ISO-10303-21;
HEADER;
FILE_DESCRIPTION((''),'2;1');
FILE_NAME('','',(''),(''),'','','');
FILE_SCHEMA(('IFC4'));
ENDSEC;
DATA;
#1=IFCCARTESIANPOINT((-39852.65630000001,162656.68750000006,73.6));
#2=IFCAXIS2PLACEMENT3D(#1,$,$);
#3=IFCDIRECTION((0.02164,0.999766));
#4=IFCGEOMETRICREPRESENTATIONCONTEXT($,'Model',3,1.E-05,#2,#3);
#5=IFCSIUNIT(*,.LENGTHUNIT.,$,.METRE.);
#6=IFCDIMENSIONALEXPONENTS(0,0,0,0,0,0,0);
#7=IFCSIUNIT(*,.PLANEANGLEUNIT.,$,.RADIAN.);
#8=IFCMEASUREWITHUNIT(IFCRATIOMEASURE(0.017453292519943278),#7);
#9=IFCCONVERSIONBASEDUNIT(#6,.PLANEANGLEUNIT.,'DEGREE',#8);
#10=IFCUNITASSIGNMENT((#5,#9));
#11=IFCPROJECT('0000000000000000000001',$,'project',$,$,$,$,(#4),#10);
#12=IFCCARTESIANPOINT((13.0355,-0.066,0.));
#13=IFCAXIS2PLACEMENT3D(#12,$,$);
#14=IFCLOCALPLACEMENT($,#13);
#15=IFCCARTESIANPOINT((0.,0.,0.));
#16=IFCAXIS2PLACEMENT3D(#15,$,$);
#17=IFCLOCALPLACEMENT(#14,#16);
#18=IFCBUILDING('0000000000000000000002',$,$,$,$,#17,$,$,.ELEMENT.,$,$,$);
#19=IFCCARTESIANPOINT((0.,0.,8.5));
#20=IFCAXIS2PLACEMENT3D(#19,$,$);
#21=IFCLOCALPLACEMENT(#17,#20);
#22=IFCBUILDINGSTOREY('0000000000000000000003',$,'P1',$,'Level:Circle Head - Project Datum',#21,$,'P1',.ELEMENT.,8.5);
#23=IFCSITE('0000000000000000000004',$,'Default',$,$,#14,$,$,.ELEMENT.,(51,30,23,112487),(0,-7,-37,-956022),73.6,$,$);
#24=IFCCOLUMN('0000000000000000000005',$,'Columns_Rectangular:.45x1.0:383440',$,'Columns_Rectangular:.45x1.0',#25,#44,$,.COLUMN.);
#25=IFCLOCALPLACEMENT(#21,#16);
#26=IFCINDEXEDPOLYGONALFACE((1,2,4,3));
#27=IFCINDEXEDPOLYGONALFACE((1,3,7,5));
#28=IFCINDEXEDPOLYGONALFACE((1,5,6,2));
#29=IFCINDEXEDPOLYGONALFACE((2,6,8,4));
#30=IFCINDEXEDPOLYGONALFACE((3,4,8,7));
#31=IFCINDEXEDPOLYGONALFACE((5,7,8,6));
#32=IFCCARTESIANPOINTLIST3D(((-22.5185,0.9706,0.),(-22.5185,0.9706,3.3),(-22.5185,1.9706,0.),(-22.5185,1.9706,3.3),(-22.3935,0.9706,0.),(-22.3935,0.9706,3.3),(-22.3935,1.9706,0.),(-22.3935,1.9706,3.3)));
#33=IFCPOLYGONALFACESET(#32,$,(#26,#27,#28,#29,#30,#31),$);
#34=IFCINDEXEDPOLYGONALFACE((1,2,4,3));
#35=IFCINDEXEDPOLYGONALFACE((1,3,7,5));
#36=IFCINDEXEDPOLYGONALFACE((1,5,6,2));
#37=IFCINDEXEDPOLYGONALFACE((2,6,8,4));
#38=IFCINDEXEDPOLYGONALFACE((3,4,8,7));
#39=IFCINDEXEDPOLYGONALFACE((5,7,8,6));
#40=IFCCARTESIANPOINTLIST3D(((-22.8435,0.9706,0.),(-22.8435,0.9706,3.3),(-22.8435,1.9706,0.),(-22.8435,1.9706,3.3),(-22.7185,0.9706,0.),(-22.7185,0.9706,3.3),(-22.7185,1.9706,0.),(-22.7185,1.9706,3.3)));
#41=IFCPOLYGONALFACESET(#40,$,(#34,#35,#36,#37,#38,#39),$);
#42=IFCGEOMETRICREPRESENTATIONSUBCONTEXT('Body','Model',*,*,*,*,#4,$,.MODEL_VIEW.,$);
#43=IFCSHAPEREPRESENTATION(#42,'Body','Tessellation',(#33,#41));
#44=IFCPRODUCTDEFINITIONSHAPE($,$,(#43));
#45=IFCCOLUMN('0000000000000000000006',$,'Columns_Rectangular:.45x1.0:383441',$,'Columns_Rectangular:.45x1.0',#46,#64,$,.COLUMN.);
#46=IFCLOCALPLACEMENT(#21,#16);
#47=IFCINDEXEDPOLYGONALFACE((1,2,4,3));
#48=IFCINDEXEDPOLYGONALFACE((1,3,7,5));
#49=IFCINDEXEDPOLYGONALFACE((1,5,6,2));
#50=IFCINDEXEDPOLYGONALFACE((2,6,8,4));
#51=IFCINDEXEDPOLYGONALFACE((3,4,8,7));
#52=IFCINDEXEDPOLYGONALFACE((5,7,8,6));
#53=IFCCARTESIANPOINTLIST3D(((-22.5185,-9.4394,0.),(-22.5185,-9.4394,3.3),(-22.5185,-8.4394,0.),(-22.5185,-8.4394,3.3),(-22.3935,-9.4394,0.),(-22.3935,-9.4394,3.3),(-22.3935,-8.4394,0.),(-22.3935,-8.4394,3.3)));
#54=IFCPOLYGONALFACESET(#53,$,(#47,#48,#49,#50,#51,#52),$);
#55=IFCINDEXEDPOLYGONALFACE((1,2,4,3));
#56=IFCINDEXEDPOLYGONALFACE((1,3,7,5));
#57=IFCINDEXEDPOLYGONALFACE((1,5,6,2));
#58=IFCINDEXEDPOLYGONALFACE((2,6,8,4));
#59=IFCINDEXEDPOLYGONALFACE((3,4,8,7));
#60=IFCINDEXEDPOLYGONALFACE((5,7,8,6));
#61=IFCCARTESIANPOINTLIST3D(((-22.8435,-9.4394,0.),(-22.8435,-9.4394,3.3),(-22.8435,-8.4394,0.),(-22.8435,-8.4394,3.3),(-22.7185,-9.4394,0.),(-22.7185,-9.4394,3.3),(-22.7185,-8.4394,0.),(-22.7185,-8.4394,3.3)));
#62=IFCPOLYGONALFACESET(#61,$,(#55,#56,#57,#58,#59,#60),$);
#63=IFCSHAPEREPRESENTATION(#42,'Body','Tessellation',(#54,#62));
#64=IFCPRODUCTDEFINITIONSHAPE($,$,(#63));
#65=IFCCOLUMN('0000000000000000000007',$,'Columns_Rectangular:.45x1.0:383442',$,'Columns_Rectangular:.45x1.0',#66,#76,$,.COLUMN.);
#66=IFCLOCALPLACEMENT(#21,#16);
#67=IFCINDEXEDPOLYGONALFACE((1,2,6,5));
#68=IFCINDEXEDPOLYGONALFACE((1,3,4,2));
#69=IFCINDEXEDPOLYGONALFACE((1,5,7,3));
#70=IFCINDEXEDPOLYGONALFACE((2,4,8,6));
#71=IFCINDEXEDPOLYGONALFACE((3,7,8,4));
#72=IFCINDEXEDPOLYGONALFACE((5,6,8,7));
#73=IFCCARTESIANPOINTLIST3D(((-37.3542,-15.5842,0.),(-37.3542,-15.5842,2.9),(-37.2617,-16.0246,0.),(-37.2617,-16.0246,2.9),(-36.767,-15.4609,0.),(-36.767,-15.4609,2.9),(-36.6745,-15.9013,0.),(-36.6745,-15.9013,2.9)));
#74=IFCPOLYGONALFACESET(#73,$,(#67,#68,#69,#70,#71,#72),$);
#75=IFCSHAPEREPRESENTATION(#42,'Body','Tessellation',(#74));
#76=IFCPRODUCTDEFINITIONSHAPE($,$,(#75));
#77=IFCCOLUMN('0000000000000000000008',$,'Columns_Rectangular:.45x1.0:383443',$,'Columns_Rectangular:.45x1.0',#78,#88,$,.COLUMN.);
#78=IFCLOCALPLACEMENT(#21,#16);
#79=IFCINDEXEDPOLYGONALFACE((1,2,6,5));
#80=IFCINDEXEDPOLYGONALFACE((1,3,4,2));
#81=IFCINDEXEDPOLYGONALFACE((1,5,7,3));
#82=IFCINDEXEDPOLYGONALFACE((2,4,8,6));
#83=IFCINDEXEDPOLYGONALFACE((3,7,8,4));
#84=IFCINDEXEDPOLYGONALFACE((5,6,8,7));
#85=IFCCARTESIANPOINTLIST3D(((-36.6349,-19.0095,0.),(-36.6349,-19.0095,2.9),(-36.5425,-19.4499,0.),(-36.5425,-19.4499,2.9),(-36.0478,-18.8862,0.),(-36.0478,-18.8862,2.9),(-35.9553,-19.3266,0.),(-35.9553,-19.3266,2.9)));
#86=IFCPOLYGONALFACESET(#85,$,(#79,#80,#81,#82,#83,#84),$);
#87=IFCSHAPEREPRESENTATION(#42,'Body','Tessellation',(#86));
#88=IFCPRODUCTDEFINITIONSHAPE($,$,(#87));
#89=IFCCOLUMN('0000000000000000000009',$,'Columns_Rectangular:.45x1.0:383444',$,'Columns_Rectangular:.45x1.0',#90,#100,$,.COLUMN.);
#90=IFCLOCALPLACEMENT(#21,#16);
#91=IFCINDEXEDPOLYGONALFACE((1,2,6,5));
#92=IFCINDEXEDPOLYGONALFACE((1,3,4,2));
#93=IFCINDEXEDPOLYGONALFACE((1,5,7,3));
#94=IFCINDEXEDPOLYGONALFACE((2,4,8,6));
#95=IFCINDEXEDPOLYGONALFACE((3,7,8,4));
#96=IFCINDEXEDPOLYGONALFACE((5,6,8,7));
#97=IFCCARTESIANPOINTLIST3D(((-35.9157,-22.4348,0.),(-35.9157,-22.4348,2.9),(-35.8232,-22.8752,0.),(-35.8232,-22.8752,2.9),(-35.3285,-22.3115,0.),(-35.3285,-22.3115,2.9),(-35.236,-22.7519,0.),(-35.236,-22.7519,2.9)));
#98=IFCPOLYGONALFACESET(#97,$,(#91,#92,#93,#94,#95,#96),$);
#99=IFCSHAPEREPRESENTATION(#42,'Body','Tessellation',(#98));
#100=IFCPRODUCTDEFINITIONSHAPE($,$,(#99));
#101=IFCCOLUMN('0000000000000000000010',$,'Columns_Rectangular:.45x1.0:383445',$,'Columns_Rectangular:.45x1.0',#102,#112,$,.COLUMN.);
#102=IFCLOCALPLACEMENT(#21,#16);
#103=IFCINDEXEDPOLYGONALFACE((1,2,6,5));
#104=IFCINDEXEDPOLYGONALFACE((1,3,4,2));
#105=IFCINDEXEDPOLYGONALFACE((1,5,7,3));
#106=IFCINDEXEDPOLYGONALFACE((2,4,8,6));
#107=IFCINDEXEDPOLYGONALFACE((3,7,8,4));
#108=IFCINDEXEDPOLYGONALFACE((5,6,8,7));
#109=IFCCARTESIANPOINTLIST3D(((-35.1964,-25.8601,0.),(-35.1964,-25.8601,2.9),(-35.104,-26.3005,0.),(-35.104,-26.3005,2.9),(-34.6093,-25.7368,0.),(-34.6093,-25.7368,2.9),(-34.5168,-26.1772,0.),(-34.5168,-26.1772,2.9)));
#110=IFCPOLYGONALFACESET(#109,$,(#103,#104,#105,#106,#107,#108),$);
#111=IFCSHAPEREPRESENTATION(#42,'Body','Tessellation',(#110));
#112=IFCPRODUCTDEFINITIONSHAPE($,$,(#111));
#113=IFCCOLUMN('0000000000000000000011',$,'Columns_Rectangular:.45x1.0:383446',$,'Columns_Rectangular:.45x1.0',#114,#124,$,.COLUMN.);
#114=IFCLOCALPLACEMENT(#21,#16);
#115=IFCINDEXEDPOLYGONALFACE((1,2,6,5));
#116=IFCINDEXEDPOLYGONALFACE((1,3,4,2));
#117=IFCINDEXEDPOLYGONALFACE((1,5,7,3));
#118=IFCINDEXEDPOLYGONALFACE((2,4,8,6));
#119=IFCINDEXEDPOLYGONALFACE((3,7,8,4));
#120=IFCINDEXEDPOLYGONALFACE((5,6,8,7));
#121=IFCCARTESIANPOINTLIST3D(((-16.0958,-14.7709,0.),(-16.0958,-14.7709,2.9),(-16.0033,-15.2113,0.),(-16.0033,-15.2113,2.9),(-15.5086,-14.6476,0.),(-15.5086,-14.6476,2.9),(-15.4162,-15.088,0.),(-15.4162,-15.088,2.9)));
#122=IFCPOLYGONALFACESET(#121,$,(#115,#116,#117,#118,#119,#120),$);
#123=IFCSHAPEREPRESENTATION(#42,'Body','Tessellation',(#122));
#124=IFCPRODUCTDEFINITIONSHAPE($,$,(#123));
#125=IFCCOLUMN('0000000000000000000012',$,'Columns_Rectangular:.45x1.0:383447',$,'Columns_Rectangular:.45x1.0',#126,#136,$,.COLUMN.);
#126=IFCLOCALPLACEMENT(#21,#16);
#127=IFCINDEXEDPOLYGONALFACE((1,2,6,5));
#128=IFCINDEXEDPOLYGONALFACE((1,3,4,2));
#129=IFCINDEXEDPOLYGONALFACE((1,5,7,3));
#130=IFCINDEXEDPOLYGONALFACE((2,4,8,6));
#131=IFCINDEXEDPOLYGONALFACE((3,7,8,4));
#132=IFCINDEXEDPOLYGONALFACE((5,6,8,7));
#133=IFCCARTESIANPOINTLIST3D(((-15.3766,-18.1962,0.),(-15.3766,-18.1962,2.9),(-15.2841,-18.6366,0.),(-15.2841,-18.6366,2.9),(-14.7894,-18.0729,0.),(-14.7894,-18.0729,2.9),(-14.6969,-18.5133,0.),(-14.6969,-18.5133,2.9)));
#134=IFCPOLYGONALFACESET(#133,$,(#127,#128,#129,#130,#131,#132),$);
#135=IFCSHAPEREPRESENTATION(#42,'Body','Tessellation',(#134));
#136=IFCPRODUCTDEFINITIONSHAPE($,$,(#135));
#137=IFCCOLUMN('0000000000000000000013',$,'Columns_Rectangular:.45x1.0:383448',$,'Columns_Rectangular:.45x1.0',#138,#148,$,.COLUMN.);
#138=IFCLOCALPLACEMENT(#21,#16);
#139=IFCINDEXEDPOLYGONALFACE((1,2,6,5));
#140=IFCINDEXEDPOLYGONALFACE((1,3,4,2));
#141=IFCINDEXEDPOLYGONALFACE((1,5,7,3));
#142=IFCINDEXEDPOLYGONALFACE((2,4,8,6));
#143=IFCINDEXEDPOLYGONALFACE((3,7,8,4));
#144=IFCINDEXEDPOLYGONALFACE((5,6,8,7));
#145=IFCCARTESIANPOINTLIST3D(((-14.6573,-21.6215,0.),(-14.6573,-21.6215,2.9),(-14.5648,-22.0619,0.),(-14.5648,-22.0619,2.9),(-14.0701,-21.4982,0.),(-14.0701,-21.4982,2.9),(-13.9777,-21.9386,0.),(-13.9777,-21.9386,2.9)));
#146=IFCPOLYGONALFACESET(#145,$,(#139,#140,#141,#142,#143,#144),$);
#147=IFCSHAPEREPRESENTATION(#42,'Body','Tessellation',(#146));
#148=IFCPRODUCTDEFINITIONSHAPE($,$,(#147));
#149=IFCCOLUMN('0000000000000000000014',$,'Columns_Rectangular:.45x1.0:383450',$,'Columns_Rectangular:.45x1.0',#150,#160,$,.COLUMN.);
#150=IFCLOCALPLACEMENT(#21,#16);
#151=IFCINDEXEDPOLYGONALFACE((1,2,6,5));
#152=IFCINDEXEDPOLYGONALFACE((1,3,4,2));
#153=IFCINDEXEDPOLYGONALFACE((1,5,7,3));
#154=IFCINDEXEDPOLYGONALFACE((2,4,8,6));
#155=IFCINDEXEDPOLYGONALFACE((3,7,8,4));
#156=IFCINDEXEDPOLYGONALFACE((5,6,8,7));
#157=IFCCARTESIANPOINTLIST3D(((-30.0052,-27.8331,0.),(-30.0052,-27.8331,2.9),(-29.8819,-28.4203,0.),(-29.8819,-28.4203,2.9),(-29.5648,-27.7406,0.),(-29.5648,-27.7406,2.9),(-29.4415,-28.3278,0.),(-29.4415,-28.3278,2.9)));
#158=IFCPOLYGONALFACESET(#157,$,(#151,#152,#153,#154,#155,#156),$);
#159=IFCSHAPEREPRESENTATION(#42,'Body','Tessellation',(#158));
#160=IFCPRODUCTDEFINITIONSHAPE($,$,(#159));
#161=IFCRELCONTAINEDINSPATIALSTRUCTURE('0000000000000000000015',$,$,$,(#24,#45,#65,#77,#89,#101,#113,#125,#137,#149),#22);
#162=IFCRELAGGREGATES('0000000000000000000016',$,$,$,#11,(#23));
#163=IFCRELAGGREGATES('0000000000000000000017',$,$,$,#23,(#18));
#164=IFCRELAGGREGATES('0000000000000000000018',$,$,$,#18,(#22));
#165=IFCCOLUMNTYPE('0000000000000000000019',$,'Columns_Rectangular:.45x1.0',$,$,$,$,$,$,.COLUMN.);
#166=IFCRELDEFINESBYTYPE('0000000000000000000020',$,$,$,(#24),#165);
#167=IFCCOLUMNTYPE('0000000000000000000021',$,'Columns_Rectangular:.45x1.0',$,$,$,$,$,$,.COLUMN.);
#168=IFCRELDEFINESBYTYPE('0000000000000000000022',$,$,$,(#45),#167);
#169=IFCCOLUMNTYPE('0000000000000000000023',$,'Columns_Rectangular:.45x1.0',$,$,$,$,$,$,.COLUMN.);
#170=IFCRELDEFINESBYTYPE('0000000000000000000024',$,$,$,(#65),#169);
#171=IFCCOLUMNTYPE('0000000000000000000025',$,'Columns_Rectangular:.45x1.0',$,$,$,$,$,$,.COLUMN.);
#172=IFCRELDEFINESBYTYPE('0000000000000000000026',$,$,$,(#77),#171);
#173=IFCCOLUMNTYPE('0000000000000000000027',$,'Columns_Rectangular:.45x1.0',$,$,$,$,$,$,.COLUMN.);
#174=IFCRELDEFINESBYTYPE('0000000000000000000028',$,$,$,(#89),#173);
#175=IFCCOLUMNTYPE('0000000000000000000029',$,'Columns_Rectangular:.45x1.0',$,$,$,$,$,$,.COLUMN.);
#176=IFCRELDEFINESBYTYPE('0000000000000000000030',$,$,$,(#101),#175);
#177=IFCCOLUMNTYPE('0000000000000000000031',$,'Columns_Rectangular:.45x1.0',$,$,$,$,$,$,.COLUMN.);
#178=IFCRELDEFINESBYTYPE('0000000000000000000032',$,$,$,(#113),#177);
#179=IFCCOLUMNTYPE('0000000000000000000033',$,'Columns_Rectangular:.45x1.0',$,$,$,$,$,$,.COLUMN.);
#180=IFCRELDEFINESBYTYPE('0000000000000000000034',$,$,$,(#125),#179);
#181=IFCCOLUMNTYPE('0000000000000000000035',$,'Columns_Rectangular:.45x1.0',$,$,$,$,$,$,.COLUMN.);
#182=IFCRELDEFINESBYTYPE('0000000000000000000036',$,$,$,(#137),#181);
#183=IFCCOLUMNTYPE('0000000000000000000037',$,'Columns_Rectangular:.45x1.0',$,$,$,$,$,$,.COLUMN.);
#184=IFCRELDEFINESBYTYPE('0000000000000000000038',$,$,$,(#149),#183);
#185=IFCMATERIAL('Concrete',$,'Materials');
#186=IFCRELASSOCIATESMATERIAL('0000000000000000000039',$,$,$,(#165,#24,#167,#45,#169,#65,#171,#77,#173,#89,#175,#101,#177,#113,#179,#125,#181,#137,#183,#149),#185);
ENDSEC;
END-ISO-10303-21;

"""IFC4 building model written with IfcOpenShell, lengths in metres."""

from ifc_helpers import new_model, entity, si_unit, converted_unit, direction, frame, origin, place, context, subcontext, project, spatial, indexed_curve, outline, extrude, source, transform, mapped, material, type_object, type_shapes, element, save


model = new_model("IFC4")

# Units and contexts
model_context = context("Model", 3, precision=1e-05, world=frame((-39852.65630000001, 162656.68750000006, 73.6)), true_north=direction((0.02164, 0.999766)))
body_context = subcontext(model_context, "Body", "Model", "MODEL_VIEW")
ifc_project = project(units=[si_unit("LENGTHUNIT", "METRE"), converted_unit("PLANEANGLEUNIT", "DEGREE", entity("IfcRatioMeasure", 0.017453292519943278), si_unit("PLANEANGLEUNIT", "RADIAN"), dimensions=[0, 0, 0, 0, 0, 0, 0])], contexts=[model_context])

# Site, building, storey
site_placement = place(None, frame((13.0355, -0.066, 0.0)))
site = spatial("IfcSite", under=ifc_project, at=site_placement, Name="Default", CompositionType="ELEMENT", RefLatitude=(51, 30, 23, 112487), RefLongitude=(0, -7, -37, -956022), RefElevation=73.6)
building_placement = place(site_placement, origin())
building = spatial("IfcBuilding", under=site, at=building_placement, CompositionType="ELEMENT")
storey_placement = place(building_placement, frame((0.0, 0.0, 8.5)))
storey = spatial("IfcBuildingStorey", under=building, at=storey_placement, Name="P1", ObjectType="Level:Circle Head - Project Datum", LongName="P1", CompositionType="ELEMENT", Elevation=8.5)

# Columns
ifc_material = material(Name="Concrete", Category="Materials")
column_type_1 = type_object("IfcColumnType", Name="Columns_Rectangular:.45x1.0", PredefinedType="COLUMN", material=ifc_material)
shared_shape_1 = source(origin(), body_context, "Body", "SweptSolid", [
    extrude(outline(indexed_curve([(-0.5, -0.0625), (0.5, -0.0625), (0.5, 0.0625), (-0.5, 0.0625), (-0.5, -0.0625)], self_intersect=False)), frame((-22.456, 1.4706, 8.5), z_axis=(0.0, 0.0, 1.0), x_axis=(0.0, -1.0, 0.0)), (0.0, 0.0, 1.0), 3.3),
    extrude(outline(indexed_curve([(-0.5, -0.0625), (0.5, -0.0625), (0.5, 0.0625), (-0.5, 0.0625), (-0.5, -0.0625)], self_intersect=False)), frame((-22.781, 1.4706, 8.5), z_axis=(0.0, 0.0, 1.0), x_axis=(0.0, -1.0, 0.0)), (0.0, 0.0, 1.0), 3.3),
])
type_shapes(column_type_1, [shared_shape_1])
column_1_placement = place(storey_placement, frame((0.0, 0.0, -8.5)))
element("IfcColumn", 1, at=column_1_placement, inside=storey, type_object=column_type_1, material=ifc_material, Name="Columns_Rectangular:.45x1.0:383440", ObjectType="Columns_Rectangular:.45x1.0", PredefinedType="COLUMN", context=body_context, shape_type="MappedRepresentation", body=[
    mapped(shared_shape_1, transform((0.0, 0.0, 0.0), scale=1.0)),
])
column_type_2 = type_object("IfcColumnType", Name="Columns_Rectangular:.45x1.0", PredefinedType="COLUMN", material=ifc_material)
shared_shape_2 = source(origin(), body_context, "Body", "SweptSolid", [
    extrude(outline(indexed_curve([(-0.5, -0.0625), (0.5, -0.0625), (0.5, 0.0625), (-0.5, 0.0625), (-0.5, -0.0625)], self_intersect=False)), frame((-22.456, -8.9394, 8.5), z_axis=(0.0, 0.0, 1.0), x_axis=(0.0, -1.0, 0.0)), (0.0, 0.0, 1.0), 3.3),
    extrude(outline(indexed_curve([(-0.5, -0.0625), (0.5, -0.0625), (0.5, 0.0625), (-0.5, 0.0625), (-0.5, -0.0625)], self_intersect=False)), frame((-22.781, -8.9394, 8.5), z_axis=(0.0, 0.0, 1.0), x_axis=(0.0, -1.0, 0.0)), (0.0, 0.0, 1.0), 3.3),
])
type_shapes(column_type_2, [shared_shape_2])
column_2_placement = place(storey_placement, frame((0.0, 0.0, -8.5)))
element("IfcColumn", 2, at=column_2_placement, inside=storey, type_object=column_type_2, material=ifc_material, Name="Columns_Rectangular:.45x1.0:383441", ObjectType="Columns_Rectangular:.45x1.0", PredefinedType="COLUMN", context=body_context, shape_type="MappedRepresentation", body=[
    mapped(shared_shape_2, transform((0.0, 0.0, 0.0), scale=1.0)),
])
column_type_3 = type_object("IfcColumnType", Name="Columns_Rectangular:.45x1.0", PredefinedType="COLUMN", material=ifc_material)
shared_shape_3 = source(origin(), body_context, "Body", "SweptSolid", [
    extrude(outline(indexed_curve([(-0.3, -0.225), (0.3, -0.225), (0.3, 0.225), (-0.3, 0.225), (-0.3, -0.225)], self_intersect=False)), frame((-37.0144, -15.7427, 8.5), z_axis=(0.0, 0.0, 1.0), x_axis=(-0.978657, -0.2055, 0.0)), (0.0, 0.0, 1.0), 2.9),
])
type_shapes(column_type_3, [shared_shape_3])
column_3_placement = place(storey_placement, frame((0.0, 0.0, -8.5)))
element("IfcColumn", 3, at=column_3_placement, inside=storey, type_object=column_type_3, material=ifc_material, Name="Columns_Rectangular:.45x1.0:383442", ObjectType="Columns_Rectangular:.45x1.0", PredefinedType="COLUMN", context=body_context, shape_type="MappedRepresentation", body=[
    mapped(shared_shape_3, transform((0.0, 0.0, 0.0), scale=1.0)),
])
column_type_4 = type_object("IfcColumnType", Name="Columns_Rectangular:.45x1.0", PredefinedType="COLUMN", material=ifc_material)
shared_shape_4 = source(origin(), body_context, "Body", "SweptSolid", [
    extrude(outline(indexed_curve([(-0.3, -0.225), (0.3, -0.225), (0.3, 0.225), (-0.3, 0.225), (-0.3, -0.225)], self_intersect=False)), frame((-36.2951, -19.168, 8.5), z_axis=(0.0, 0.0, 1.0), x_axis=(-0.978657, -0.2055, 0.0)), (0.0, 0.0, 1.0), 2.9),
])
type_shapes(column_type_4, [shared_shape_4])
column_4_placement = place(storey_placement, frame((0.0, 0.0, -8.5)))
element("IfcColumn", 4, at=column_4_placement, inside=storey, type_object=column_type_4, material=ifc_material, Name="Columns_Rectangular:.45x1.0:383443", ObjectType="Columns_Rectangular:.45x1.0", PredefinedType="COLUMN", context=body_context, shape_type="MappedRepresentation", body=[
    mapped(shared_shape_4, transform((0.0, 0.0, 0.0), scale=1.0)),
])
column_type_5 = type_object("IfcColumnType", Name="Columns_Rectangular:.45x1.0", PredefinedType="COLUMN", material=ifc_material)
shared_shape_5 = source(origin(), body_context, "Body", "SweptSolid", [
    extrude(outline(indexed_curve([(-0.3, -0.225), (0.3, -0.225), (0.3, 0.225), (-0.3, 0.225), (-0.3, -0.225)], self_intersect=False)), frame((-35.5759, -22.5933, 8.5), z_axis=(0.0, 0.0, 1.0), x_axis=(-0.978657, -0.2055, 0.0)), (0.0, 0.0, 1.0), 2.9),
])
type_shapes(column_type_5, [shared_shape_5])
column_5_placement = place(storey_placement, frame((0.0, 0.0, -8.5)))
element("IfcColumn", 5, at=column_5_placement, inside=storey, type_object=column_type_5, material=ifc_material, Name="Columns_Rectangular:.45x1.0:383444", ObjectType="Columns_Rectangular:.45x1.0", PredefinedType="COLUMN", context=body_context, shape_type="MappedRepresentation", body=[
    mapped(shared_shape_5, transform((0.0, 0.0, 0.0), scale=1.0)),
])
column_type_6 = type_object("IfcColumnType", Name="Columns_Rectangular:.45x1.0", PredefinedType="COLUMN", material=ifc_material)
shared_shape_6 = source(origin(), body_context, "Body", "SweptSolid", [
    extrude(outline(indexed_curve([(-0.3, -0.225), (0.3, -0.225), (0.3, 0.225), (-0.3, 0.225), (-0.3, -0.225)], self_intersect=False)), frame((-34.8566, -26.0186, 8.5), z_axis=(0.0, 0.0, 1.0), x_axis=(-0.978657, -0.2055, 0.0)), (0.0, 0.0, 1.0), 2.9),
])
type_shapes(column_type_6, [shared_shape_6])
column_6_placement = place(storey_placement, frame((0.0, 0.0, -8.5)))
element("IfcColumn", 6, at=column_6_placement, inside=storey, type_object=column_type_6, material=ifc_material, Name="Columns_Rectangular:.45x1.0:383445", ObjectType="Columns_Rectangular:.45x1.0", PredefinedType="COLUMN", context=body_context, shape_type="MappedRepresentation", body=[
    mapped(shared_shape_6, transform((0.0, 0.0, 0.0), scale=1.0)),
])
column_type_7 = type_object("IfcColumnType", Name="Columns_Rectangular:.45x1.0", PredefinedType="COLUMN", material=ifc_material)
shared_shape_7 = source(origin(), body_context, "Body", "SweptSolid", [
    extrude(outline(indexed_curve([(-0.3, -0.225), (0.3, -0.225), (0.3, 0.225), (-0.3, 0.225), (-0.3, -0.225)], self_intersect=False)), frame((-15.756, -14.9295, 8.5), z_axis=(0.0, 0.0, 1.0), x_axis=(-0.978657, -0.2055, 0.0)), (0.0, 0.0, 1.0), 2.9),
])
type_shapes(column_type_7, [shared_shape_7])
column_7_placement = place(storey_placement, frame((0.0, 0.0, -8.5)))
element("IfcColumn", 7, at=column_7_placement, inside=storey, type_object=column_type_7, material=ifc_material, Name="Columns_Rectangular:.45x1.0:383446", ObjectType="Columns_Rectangular:.45x1.0", PredefinedType="COLUMN", context=body_context, shape_type="MappedRepresentation", body=[
    mapped(shared_shape_7, transform((0.0, 0.0, 0.0), scale=1.0)),
])
column_type_8 = type_object("IfcColumnType", Name="Columns_Rectangular:.45x1.0", PredefinedType="COLUMN", material=ifc_material)
shared_shape_8 = source(origin(), body_context, "Body", "SweptSolid", [
    extrude(outline(indexed_curve([(-0.3, -0.225), (0.3, -0.225), (0.3, 0.225), (-0.3, 0.225), (-0.3, -0.225)], self_intersect=False)), frame((-15.0367, -18.3548, 8.5), z_axis=(0.0, 0.0, 1.0), x_axis=(-0.978657, -0.2055, 0.0)), (0.0, 0.0, 1.0), 2.9),
])
type_shapes(column_type_8, [shared_shape_8])
column_8_placement = place(storey_placement, frame((0.0, 0.0, -8.5)))
element("IfcColumn", 8, at=column_8_placement, inside=storey, type_object=column_type_8, material=ifc_material, Name="Columns_Rectangular:.45x1.0:383447", ObjectType="Columns_Rectangular:.45x1.0", PredefinedType="COLUMN", context=body_context, shape_type="MappedRepresentation", body=[
    mapped(shared_shape_8, transform((0.0, 0.0, 0.0), scale=1.0)),
])
column_type_9 = type_object("IfcColumnType", Name="Columns_Rectangular:.45x1.0", PredefinedType="COLUMN", material=ifc_material)
shared_shape_9 = source(origin(), body_context, "Body", "SweptSolid", [
    extrude(outline(indexed_curve([(-0.3, -0.225), (0.3, -0.225), (0.3, 0.225), (-0.3, 0.225), (-0.3, -0.225)], self_intersect=False)), frame((-14.3175, -21.7801, 8.5), z_axis=(0.0, 0.0, 1.0), x_axis=(-0.978657, -0.2055, 0.0)), (0.0, 0.0, 1.0), 2.9),
])
type_shapes(column_type_9, [shared_shape_9])
column_9_placement = place(storey_placement, frame((0.0, 0.0, -8.5)))
element("IfcColumn", 9, at=column_9_placement, inside=storey, type_object=column_type_9, material=ifc_material, Name="Columns_Rectangular:.45x1.0:383448", ObjectType="Columns_Rectangular:.45x1.0", PredefinedType="COLUMN", context=body_context, shape_type="MappedRepresentation", body=[
    mapped(shared_shape_9, transform((0.0, 0.0, 0.0), scale=1.0)),
])
column_type_10 = type_object("IfcColumnType", Name="Columns_Rectangular:.45x1.0", PredefinedType="COLUMN", material=ifc_material)
shared_shape_10 = source(origin(), body_context, "Body", "SweptSolid", [
    extrude(outline(indexed_curve([(-0.3, -0.225), (0.3, -0.225), (0.3, 0.225), (-0.3, 0.225), (-0.3, -0.225)], self_intersect=False)), frame((-29.7234, -28.0804, 8.5), z_axis=(0.0, 0.0, 1.0), x_axis=(-0.2055, 0.978657, 0.0)), (0.0, 0.0, 1.0), 2.9),
])
type_shapes(column_type_10, [shared_shape_10])
column_10_placement = place(storey_placement, frame((0.0, 0.0, -8.5)))
element("IfcColumn", 10, at=column_10_placement, inside=storey, type_object=column_type_10, material=ifc_material, Name="Columns_Rectangular:.45x1.0:383450", ObjectType="Columns_Rectangular:.45x1.0", PredefinedType="COLUMN", context=body_context, shape_type="MappedRepresentation", body=[
    mapped(shared_shape_10, transform((0.0, 0.0, 0.0), scale=1.0)),
])

save(model, "model.ifc")
